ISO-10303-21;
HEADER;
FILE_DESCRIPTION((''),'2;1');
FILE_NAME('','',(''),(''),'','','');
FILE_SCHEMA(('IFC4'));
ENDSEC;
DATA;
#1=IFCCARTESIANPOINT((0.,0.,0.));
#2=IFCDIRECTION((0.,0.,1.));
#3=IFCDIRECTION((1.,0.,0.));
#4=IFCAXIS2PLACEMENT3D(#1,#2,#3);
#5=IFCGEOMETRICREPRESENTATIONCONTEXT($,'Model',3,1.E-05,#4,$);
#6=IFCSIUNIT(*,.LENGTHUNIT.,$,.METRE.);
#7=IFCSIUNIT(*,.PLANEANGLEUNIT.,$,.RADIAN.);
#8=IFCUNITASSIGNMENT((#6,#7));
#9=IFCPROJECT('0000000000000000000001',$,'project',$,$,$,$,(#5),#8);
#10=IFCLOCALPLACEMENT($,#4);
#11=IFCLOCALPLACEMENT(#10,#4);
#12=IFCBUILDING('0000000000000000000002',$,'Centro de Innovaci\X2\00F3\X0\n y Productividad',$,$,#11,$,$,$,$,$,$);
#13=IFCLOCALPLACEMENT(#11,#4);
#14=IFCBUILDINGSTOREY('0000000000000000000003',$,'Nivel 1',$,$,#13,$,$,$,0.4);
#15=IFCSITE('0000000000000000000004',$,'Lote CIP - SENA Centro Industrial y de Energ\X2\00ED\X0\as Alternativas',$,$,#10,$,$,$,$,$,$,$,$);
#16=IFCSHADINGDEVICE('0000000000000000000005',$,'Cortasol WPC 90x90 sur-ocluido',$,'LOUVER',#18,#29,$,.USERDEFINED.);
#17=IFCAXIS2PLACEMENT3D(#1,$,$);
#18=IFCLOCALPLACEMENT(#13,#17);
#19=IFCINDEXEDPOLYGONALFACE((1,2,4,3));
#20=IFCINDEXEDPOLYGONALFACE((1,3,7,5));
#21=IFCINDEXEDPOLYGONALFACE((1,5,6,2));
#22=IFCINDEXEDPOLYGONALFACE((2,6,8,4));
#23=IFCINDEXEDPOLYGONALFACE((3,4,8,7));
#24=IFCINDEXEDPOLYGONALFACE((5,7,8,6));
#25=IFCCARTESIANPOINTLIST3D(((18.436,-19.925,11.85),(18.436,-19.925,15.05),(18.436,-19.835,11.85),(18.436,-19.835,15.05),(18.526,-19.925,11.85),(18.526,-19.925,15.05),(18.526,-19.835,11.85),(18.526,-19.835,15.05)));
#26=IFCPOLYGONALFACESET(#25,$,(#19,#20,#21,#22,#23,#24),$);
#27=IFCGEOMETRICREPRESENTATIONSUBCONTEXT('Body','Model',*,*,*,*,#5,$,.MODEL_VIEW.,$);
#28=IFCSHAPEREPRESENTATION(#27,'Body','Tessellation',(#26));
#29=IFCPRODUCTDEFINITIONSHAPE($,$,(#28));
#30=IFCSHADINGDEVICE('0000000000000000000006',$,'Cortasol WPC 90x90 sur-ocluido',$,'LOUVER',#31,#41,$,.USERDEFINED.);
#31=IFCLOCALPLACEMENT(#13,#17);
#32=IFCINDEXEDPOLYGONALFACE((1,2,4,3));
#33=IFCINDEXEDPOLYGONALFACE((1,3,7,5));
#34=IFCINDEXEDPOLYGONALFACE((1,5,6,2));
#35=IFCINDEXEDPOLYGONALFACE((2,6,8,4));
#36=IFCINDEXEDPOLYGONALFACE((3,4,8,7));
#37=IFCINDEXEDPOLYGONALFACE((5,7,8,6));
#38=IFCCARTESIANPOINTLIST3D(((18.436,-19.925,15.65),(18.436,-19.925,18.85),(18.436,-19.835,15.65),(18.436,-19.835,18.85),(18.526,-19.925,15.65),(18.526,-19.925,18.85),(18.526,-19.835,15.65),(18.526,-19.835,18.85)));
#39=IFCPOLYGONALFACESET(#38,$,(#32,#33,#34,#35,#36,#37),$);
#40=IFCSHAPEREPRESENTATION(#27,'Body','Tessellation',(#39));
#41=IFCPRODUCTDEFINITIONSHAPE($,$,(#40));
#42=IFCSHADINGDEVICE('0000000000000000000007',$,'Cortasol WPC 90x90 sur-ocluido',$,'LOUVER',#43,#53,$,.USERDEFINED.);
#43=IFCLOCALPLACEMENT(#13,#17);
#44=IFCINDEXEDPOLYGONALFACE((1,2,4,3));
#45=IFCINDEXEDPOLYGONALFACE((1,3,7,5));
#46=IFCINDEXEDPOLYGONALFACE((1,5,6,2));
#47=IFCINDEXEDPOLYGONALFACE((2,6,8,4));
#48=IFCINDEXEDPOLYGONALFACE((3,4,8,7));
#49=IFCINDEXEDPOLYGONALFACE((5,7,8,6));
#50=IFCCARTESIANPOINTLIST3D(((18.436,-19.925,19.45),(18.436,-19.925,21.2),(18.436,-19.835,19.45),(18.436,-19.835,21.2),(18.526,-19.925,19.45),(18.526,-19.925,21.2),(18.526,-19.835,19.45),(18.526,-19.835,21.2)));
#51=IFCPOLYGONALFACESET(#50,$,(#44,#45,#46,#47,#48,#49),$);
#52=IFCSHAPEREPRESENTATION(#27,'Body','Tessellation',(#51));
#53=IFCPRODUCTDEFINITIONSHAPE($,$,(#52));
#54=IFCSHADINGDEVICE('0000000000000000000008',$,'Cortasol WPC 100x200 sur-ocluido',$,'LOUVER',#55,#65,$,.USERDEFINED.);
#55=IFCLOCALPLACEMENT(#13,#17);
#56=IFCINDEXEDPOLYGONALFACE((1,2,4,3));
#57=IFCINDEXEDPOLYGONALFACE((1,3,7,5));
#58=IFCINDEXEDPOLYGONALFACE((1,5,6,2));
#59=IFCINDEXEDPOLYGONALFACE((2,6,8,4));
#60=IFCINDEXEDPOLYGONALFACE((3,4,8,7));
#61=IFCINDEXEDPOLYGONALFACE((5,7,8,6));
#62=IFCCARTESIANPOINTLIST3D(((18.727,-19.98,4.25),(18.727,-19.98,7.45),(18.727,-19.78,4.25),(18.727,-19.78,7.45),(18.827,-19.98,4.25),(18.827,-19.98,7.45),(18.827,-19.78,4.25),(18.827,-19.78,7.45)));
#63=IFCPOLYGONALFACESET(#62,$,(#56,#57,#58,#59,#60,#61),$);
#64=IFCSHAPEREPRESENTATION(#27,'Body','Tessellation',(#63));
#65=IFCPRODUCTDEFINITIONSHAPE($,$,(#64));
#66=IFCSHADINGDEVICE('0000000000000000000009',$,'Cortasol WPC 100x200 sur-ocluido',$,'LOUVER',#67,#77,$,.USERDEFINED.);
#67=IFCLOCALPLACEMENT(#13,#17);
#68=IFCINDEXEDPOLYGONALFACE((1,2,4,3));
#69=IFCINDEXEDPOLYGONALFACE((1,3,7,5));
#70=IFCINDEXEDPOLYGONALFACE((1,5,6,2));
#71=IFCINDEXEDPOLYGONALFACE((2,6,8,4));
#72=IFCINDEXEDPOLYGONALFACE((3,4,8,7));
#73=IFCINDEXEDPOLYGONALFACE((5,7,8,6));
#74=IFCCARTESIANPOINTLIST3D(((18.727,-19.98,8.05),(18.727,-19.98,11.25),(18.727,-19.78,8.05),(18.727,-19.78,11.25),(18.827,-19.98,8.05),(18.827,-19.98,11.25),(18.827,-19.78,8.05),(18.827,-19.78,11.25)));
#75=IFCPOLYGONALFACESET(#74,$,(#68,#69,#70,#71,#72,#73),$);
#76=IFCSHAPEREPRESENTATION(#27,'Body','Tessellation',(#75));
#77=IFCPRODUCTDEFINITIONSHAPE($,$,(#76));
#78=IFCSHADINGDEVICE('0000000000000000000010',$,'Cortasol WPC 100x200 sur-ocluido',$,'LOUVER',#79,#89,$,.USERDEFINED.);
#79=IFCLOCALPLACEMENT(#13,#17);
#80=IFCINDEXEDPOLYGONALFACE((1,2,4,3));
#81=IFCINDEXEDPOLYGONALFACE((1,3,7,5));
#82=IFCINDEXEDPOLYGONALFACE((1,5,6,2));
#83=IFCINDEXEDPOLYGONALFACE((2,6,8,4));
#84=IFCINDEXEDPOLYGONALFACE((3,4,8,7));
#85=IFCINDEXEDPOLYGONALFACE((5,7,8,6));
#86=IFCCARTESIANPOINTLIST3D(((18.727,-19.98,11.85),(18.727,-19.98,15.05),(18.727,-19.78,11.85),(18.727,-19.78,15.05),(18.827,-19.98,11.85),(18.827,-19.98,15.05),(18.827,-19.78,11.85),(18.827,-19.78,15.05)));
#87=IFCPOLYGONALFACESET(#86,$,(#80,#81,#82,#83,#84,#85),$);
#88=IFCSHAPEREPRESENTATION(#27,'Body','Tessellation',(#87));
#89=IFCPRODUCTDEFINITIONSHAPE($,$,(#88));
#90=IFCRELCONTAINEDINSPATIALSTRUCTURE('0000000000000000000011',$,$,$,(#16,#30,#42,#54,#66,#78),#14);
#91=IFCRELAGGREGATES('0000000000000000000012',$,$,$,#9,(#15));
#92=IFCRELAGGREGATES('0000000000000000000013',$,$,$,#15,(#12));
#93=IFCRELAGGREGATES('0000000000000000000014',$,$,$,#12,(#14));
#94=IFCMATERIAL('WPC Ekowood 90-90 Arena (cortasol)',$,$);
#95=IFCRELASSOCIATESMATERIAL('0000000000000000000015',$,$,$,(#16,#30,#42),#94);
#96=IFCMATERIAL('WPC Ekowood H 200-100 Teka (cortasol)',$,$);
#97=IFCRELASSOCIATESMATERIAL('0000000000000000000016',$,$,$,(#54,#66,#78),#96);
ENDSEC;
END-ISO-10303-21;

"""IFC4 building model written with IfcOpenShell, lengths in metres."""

from ifc_helpers import new_model, si_unit, frame, origin_with_axes, place, context, subcontext, project, spatial, polyline, outline, extrude, material, element, save


model = new_model("IFC4")

# Units and contexts
model_context = context("Model", 3, precision=1e-05, world=origin_with_axes())
body_context = subcontext(model_context, "Body", "Model", "MODEL_VIEW")
ifc_project = project(units=[si_unit("LENGTHUNIT", "METRE"), si_unit("PLANEANGLEUNIT", "RADIAN")], contexts=[model_context])

# Site, building, storey
site_placement = place(None, origin_with_axes())
site = spatial("IfcSite", under=ifc_project, at=site_placement, Name="Lote CIP - SENA Centro Industrial y de Energías Alternativas")
building_placement = place(site_placement, origin_with_axes())
building = spatial("IfcBuilding", under=site, at=building_placement, Name="Centro de Innovación y Productividad")
storey_placement = place(building_placement, origin_with_axes())
storey = spatial("IfcBuildingStorey", under=building, at=storey_placement, Name="Nivel 1", Elevation=0.4)

# Shading devices
ifc_material_1 = material(Name="WPC Ekowood H 200-100 Teka (cortasol)")
ifc_material_2 = material(Name="WPC Ekowood 90-90 Arena (cortasol)")
shading_device_1_placement = place(storey_placement, origin_with_axes())
element("IfcShadingDevice", 1, at=shading_device_1_placement, inside=storey, material=ifc_material_2, Name="Cortasol WPC 90x90 sur-ocluido", ObjectType="LOUVER", PredefinedType="USERDEFINED", context=body_context, shape_type="SweptSolid", body=[
    extrude(outline(polyline([(18.436, -19.925), (18.436, -19.835), (18.526, -19.835), (18.526, -19.925), (18.436, -19.925)])), frame((0.0, 0.0, 11.85)), (0.0, 0.0, 1.0), 3.2),
])
shading_device_2_placement = place(storey_placement, origin_with_axes())
element("IfcShadingDevice", 2, at=shading_device_2_placement, inside=storey, material=ifc_material_2, Name="Cortasol WPC 90x90 sur-ocluido", ObjectType="LOUVER", PredefinedType="USERDEFINED", context=body_context, shape_type="SweptSolid", body=[
    extrude(outline(polyline([(18.436, -19.925), (18.436, -19.835), (18.526, -19.835), (18.526, -19.925), (18.436, -19.925)])), frame((0.0, 0.0, 15.65)), (0.0, 0.0, 1.0), 3.2),
])
shading_device_3_placement = place(storey_placement, origin_with_axes())
element("IfcShadingDevice", 3, at=shading_device_3_placement, inside=storey, material=ifc_material_2, Name="Cortasol WPC 90x90 sur-ocluido", ObjectType="LOUVER", PredefinedType="USERDEFINED", context=body_context, shape_type="SweptSolid", body=[
    extrude(outline(polyline([(18.436, -19.925), (18.436, -19.835), (18.526, -19.835), (18.526, -19.925), (18.436, -19.925)])), frame((0.0, 0.0, 19.45)), (0.0, 0.0, 1.0), 1.75),
])
shading_device_4_placement = place(storey_placement, origin_with_axes())
element("IfcShadingDevice", 4, at=shading_device_4_placement, inside=storey, material=ifc_material_1, Name="Cortasol WPC 100x200 sur-ocluido", ObjectType="LOUVER", PredefinedType="USERDEFINED", context=body_context, shape_type="SweptSolid", body=[
    extrude(outline(polyline([(18.727, -19.98), (18.727, -19.78), (18.827, -19.78), (18.827, -19.98), (18.727, -19.98)])), frame((0.0, 0.0, 4.25)), (0.0, 0.0, 1.0), 3.2),
])
shading_device_5_placement = place(storey_placement, origin_with_axes())
element("IfcShadingDevice", 5, at=shading_device_5_placement, inside=storey, material=ifc_material_1, Name="Cortasol WPC 100x200 sur-ocluido", ObjectType="LOUVER", PredefinedType="USERDEFINED", context=body_context, shape_type="SweptSolid", body=[
    extrude(outline(polyline([(18.727, -19.98), (18.727, -19.78), (18.827, -19.78), (18.827, -19.98), (18.727, -19.98)])), frame((0.0, 0.0, 8.05)), (0.0, 0.0, 1.0), 3.2),
])
shading_device_6_placement = place(storey_placement, origin_with_axes())
element("IfcShadingDevice", 6, at=shading_device_6_placement, inside=storey, material=ifc_material_1, Name="Cortasol WPC 100x200 sur-ocluido", ObjectType="LOUVER", PredefinedType="USERDEFINED", context=body_context, shape_type="SweptSolid", body=[
    extrude(outline(polyline([(18.727, -19.98), (18.727, -19.78), (18.827, -19.78), (18.827, -19.98), (18.727, -19.98)])), frame((0.0, 0.0, 11.85)), (0.0, 0.0, 1.0), 3.2),
])

save(model, "model.ifc")
